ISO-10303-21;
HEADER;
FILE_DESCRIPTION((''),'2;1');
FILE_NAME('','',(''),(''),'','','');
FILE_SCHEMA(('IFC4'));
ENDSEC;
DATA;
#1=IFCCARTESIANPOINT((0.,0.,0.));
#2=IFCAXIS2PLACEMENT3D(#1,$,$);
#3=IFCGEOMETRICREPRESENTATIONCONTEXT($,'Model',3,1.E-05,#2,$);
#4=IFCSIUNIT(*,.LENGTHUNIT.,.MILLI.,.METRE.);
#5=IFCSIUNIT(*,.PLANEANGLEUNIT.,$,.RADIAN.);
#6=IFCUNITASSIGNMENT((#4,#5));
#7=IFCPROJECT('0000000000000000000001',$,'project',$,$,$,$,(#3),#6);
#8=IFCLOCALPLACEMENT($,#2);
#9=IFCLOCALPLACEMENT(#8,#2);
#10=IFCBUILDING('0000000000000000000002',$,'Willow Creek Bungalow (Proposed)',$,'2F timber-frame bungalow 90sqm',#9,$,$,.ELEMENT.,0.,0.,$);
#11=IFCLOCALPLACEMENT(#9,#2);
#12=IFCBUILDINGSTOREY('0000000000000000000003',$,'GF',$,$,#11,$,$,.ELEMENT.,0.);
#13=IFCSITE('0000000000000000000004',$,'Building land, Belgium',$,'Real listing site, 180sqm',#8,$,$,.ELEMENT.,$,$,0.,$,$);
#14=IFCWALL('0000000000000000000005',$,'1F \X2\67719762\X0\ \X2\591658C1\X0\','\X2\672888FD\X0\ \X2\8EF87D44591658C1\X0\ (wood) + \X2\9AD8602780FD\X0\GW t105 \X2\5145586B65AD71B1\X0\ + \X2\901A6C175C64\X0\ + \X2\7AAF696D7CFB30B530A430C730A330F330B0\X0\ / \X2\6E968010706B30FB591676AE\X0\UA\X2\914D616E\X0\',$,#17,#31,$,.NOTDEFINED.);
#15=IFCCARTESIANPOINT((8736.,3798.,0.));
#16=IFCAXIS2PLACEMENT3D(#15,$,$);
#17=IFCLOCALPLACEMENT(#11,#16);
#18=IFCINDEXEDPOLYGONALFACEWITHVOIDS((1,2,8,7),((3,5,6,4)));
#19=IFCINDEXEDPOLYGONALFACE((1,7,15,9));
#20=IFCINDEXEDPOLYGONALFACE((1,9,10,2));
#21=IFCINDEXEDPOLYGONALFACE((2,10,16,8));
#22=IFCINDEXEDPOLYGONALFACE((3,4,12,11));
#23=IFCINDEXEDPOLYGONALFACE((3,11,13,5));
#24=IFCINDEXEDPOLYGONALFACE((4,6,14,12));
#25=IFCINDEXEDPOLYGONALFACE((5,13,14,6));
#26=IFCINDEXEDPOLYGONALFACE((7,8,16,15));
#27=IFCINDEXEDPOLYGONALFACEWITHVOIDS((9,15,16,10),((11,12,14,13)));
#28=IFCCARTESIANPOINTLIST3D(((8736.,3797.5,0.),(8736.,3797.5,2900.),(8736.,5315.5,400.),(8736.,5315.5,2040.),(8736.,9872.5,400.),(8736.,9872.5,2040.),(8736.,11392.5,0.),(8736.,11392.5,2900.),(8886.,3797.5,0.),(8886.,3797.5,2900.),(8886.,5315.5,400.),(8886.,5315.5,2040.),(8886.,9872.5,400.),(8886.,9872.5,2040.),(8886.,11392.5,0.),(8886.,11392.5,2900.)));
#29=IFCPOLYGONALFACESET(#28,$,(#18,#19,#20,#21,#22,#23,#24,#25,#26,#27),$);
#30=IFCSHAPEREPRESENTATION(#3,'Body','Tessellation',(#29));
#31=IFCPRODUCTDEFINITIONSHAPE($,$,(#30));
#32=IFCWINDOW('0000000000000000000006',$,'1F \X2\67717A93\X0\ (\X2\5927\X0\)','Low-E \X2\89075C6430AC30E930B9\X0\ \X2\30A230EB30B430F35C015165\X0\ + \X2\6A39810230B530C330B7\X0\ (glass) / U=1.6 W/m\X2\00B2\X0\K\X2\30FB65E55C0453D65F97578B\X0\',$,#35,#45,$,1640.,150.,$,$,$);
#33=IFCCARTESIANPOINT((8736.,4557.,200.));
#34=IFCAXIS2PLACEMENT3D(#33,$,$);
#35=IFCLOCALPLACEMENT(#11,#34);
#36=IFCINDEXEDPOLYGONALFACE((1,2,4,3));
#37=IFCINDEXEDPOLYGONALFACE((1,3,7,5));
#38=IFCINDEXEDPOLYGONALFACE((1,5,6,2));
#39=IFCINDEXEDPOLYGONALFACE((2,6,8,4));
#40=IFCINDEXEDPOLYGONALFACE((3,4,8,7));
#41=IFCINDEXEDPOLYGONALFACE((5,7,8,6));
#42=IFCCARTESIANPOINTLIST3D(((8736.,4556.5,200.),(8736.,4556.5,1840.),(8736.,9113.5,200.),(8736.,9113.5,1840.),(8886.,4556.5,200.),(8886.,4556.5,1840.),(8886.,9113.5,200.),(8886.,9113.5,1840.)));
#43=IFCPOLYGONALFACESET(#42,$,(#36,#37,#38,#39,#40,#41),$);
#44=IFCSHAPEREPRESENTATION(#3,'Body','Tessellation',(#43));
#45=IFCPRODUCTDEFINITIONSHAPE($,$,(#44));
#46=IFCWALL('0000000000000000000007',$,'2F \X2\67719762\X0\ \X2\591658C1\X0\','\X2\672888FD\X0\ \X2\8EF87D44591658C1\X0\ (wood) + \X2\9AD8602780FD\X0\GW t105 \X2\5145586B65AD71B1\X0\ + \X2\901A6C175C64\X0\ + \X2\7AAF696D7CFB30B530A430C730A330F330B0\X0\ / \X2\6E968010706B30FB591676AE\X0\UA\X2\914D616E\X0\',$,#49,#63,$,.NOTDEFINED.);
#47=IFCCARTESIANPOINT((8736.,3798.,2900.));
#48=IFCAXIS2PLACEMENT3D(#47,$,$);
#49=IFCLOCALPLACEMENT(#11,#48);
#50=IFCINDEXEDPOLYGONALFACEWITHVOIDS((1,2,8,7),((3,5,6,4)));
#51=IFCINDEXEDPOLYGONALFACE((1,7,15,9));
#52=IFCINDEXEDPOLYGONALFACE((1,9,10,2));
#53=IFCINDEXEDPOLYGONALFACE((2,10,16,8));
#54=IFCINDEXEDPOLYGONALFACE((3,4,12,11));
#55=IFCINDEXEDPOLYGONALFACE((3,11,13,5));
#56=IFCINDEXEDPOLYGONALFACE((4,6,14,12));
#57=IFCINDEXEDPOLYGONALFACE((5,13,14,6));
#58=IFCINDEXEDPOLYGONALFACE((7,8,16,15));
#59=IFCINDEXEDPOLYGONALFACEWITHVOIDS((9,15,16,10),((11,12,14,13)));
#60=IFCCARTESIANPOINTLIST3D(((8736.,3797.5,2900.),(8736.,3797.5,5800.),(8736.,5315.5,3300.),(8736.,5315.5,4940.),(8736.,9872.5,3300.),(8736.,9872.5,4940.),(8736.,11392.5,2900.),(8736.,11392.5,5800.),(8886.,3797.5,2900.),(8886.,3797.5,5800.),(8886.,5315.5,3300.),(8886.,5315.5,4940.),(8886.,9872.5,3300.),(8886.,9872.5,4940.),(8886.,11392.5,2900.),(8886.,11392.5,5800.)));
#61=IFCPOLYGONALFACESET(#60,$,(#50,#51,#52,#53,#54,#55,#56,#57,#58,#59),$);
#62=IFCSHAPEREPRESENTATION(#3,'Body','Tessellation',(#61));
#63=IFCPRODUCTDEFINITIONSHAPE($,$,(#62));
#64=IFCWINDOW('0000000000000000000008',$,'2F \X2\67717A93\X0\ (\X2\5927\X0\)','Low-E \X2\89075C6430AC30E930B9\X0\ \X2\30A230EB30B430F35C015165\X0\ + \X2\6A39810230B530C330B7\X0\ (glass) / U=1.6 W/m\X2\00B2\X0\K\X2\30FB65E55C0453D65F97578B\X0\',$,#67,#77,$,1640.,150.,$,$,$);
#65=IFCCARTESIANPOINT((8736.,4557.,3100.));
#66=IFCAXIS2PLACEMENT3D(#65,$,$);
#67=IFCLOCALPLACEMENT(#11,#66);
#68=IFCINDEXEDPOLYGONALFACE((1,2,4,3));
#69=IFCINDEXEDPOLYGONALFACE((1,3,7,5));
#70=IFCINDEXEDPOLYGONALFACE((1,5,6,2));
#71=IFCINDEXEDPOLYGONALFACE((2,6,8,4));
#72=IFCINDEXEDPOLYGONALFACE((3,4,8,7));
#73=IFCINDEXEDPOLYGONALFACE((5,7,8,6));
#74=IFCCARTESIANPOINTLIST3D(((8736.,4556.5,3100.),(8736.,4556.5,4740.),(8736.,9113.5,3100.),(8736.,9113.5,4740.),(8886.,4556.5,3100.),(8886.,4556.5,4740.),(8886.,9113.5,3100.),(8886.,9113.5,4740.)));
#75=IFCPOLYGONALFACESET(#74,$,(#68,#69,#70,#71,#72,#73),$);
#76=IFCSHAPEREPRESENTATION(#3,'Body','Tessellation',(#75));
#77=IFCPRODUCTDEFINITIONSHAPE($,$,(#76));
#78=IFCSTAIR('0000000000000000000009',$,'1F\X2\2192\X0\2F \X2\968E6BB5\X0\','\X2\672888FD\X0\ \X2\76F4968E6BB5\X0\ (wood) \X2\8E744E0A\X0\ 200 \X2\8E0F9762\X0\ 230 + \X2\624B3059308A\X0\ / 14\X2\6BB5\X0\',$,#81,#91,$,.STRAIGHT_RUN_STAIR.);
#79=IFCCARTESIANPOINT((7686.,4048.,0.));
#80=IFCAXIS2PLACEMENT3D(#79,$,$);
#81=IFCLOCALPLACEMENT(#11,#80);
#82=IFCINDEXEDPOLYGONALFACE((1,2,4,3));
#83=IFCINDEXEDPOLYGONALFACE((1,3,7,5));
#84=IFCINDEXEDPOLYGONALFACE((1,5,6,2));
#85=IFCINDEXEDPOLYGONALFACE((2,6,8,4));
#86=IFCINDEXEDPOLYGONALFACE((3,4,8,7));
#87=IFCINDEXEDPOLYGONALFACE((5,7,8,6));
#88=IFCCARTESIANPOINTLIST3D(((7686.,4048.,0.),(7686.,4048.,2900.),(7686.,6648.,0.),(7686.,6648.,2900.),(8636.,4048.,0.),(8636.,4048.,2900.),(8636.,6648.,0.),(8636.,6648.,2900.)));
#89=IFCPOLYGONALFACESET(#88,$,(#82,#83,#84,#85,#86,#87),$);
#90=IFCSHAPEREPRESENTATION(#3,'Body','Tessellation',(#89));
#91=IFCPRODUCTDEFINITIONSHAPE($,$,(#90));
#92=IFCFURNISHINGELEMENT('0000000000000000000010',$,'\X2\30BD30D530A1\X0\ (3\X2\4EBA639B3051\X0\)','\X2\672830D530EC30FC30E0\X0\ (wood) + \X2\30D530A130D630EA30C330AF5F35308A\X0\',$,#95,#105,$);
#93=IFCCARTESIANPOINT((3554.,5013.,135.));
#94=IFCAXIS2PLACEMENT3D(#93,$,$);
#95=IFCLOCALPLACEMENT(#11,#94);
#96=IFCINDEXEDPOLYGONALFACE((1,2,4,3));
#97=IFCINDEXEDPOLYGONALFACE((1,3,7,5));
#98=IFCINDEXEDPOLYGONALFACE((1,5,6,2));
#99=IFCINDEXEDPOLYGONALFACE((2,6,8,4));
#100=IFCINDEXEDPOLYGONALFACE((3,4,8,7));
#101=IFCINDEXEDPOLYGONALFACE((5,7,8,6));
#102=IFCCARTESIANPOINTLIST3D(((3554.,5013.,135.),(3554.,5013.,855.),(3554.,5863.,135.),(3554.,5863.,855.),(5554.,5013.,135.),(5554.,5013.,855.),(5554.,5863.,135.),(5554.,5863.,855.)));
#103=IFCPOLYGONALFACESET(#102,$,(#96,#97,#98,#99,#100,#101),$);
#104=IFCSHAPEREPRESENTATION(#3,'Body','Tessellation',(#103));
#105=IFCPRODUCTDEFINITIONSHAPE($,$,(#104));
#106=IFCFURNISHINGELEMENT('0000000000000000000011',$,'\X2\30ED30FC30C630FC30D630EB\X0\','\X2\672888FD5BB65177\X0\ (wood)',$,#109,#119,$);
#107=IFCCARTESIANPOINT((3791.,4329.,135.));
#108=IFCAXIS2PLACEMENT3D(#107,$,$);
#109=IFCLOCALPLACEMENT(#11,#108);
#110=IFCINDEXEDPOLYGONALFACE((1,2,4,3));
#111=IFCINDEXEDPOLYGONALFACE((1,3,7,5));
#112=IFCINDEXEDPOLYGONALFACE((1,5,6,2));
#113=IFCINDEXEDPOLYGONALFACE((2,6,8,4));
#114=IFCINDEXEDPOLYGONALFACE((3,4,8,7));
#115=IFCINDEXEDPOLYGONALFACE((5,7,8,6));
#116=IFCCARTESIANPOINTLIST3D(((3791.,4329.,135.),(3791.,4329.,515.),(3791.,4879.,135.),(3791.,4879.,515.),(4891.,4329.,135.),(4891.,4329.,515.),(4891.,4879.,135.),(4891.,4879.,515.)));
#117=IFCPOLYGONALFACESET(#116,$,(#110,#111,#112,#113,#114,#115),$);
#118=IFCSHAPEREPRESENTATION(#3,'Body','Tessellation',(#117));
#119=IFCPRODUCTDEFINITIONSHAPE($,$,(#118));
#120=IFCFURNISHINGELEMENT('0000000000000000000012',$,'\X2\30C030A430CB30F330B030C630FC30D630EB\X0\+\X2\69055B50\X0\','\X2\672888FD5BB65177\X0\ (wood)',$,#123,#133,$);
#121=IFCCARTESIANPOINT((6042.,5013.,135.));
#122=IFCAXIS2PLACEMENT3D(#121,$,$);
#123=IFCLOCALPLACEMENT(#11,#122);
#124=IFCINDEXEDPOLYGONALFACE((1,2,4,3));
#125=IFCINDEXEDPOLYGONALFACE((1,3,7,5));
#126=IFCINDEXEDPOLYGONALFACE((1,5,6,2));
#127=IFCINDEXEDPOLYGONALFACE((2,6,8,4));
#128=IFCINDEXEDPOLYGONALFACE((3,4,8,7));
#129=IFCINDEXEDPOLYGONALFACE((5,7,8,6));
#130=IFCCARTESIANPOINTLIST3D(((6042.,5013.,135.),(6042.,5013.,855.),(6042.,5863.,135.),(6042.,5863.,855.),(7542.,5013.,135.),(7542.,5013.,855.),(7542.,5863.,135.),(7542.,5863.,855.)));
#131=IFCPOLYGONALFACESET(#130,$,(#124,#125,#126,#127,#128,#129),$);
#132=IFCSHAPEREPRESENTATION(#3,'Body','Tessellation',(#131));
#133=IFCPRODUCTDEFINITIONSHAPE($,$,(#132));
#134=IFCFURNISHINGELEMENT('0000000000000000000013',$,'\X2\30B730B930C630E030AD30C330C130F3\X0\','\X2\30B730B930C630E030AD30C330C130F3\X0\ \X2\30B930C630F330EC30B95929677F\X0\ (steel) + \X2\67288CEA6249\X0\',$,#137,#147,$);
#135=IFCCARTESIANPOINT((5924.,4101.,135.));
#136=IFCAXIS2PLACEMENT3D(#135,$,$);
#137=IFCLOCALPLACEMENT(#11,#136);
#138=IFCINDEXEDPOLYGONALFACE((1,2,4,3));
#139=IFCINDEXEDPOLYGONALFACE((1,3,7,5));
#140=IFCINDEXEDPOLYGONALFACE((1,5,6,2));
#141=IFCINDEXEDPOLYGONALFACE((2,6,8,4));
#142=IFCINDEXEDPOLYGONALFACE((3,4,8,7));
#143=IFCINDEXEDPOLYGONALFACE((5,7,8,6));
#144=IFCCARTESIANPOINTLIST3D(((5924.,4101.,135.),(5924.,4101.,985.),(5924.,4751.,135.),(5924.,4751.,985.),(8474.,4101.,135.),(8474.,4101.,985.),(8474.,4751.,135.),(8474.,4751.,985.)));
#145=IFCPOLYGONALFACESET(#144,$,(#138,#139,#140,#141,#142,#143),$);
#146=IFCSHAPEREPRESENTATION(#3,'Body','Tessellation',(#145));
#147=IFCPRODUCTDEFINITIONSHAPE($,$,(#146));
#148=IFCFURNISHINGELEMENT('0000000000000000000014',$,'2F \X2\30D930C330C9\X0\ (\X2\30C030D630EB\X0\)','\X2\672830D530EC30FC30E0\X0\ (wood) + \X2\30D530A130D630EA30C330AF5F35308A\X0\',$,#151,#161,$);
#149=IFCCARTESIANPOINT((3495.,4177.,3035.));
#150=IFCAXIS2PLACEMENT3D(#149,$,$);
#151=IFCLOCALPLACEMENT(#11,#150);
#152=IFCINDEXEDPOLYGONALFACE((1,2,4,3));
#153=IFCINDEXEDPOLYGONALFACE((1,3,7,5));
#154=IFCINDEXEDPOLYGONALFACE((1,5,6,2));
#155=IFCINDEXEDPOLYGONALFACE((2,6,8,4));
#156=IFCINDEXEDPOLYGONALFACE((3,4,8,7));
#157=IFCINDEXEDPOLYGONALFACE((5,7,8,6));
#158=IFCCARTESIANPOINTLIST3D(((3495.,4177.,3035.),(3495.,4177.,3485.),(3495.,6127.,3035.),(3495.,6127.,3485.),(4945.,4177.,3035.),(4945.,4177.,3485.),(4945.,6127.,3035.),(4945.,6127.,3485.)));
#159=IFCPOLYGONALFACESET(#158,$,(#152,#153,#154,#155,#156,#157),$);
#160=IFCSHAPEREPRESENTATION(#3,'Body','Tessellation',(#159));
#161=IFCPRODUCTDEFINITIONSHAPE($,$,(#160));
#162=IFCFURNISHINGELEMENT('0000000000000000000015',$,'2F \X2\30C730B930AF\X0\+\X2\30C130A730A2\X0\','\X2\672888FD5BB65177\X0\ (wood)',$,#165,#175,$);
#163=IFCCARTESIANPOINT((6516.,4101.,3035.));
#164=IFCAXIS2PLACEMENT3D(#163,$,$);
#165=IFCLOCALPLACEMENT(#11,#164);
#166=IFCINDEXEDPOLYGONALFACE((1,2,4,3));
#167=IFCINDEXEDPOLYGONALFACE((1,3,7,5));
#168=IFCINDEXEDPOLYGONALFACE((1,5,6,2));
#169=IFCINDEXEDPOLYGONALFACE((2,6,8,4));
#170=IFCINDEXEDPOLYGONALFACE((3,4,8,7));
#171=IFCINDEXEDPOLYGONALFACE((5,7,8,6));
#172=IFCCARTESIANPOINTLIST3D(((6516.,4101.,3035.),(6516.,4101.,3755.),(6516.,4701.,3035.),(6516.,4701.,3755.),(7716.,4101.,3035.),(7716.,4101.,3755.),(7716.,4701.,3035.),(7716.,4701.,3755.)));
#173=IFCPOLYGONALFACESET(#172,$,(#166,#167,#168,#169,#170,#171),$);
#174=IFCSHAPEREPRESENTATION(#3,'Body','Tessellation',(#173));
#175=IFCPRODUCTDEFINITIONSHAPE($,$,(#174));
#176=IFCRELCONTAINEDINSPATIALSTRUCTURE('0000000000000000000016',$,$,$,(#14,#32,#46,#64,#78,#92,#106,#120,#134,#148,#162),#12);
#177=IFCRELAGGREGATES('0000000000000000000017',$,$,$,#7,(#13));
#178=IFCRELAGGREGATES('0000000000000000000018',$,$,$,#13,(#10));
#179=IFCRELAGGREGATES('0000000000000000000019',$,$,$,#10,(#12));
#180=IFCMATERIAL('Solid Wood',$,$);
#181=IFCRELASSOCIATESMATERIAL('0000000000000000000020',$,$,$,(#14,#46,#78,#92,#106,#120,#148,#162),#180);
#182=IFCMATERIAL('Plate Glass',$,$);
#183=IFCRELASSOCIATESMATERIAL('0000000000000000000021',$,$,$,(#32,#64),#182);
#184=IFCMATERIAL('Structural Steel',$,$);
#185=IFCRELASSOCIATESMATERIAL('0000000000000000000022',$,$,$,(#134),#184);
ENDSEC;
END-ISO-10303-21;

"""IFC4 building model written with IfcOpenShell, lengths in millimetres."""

from ifc_helpers import new_model, si_unit, frame, frame_2d, origin, place, context, project, spatial, rectangle, extrude, material, element, fill, save


model = new_model("IFC4")

# Units and contexts
model_context = context("Model", 3, precision=1e-05, world=origin())
ifc_project = project(units=[si_unit("LENGTHUNIT", "METRE", prefix="MILLI"), si_unit("PLANEANGLEUNIT", "RADIAN")], contexts=[model_context])

# Site, building, storey
site_placement = place(None, origin())
site = spatial("IfcSite", under=ifc_project, at=site_placement, Name="Building land, Belgium", ObjectType="Real listing site, 180sqm", CompositionType="ELEMENT", RefElevation=0.0)
building_placement = place(site_placement, origin())
building = spatial("IfcBuilding", under=site, at=building_placement, Name="Willow Creek Bungalow (Proposed)", ObjectType="2F timber-frame bungalow 90sqm", CompositionType="ELEMENT", ElevationOfRefHeight=0.0, ElevationOfTerrain=0.0)
storey_placement = place(building_placement, origin())
storey = spatial("IfcBuildingStorey", under=building, at=storey_placement, Name="GF", CompositionType="ELEMENT", Elevation=0.0)

# Wall, opening, window
ifc_material_1 = material(Name="Solid Wood")
wall_1_placement = place(storey_placement, frame((8736.0, 3798.0, 0.0)))
wall_1 = element("IfcWall", 1, at=wall_1_placement, inside=storey, material=ifc_material_1, Name="1F 東面 外壁", Description="木製 軸組外壁 (wood) + 高性能GW t105 充填断熱 + 通気層 + 窯業系サイディング / 準耐火・外皮UA配慮", PredefinedType="NOTDEFINED", context=model_context, shape_type="SweptSolid", body=[
    extrude(rectangle(XDim=150.0, YDim=7595.0, at=frame_2d((75.0, 3797.0))), frame((8736.0, 3798.0, 0.0)), (0.0, 0.0, 1.0), 2900.0),
])
opening_1_placement = place(storey_placement, frame((8736.0, 4557.0, 200.0)))
opening_1 = element("IfcOpeningElement", 2, at=opening_1_placement, cuts=wall_1, PredefinedType="NOTDEFINED", context=model_context, shape_type="SweptSolid", body=[
    extrude(rectangle(XDim=150.0, YDim=4557.0, at=frame_2d((75.0, 2278.0))), frame((8736.0, 4557.0, 200.0)), (0.0, 0.0, 1.0), 1640.0),
])
ifc_material_2 = material(Name="Plate Glass")
window_1_placement = place(storey_placement, frame((8736.0, 4557.0, 200.0)))
window_1 = element("IfcWindow", 3, at=window_1_placement, inside=storey, material=ifc_material_2, Name="1F 東窓 (大)", Description="Low-E 複層ガラス アルゴン封入 + 樹脂サッシ (glass) / U=1.6 W/m²K・日射取得型", OverallHeight=1640.0, OverallWidth=150.0, context=model_context, shape_type="SweptSolid", body=[
    extrude(rectangle(XDim=150.0, YDim=4557.0, at=frame_2d((75.0, 2278.0))), frame((8736.0, 4557.0, 200.0)), (0.0, 0.0, 1.0), 1640.0),
])
fill(opening_1, window_1)

# Wall, opening, window
wall_2_placement = place(storey_placement, frame((8736.0, 3798.0, 2900.0)))
wall_2 = element("IfcWall", 4, at=wall_2_placement, inside=storey, material=ifc_material_1, Name="2F 東面 外壁", Description="木製 軸組外壁 (wood) + 高性能GW t105 充填断熱 + 通気層 + 窯業系サイディング / 準耐火・外皮UA配慮", PredefinedType="NOTDEFINED", context=model_context, shape_type="SweptSolid", body=[
    extrude(rectangle(XDim=150.0, YDim=7595.0, at=frame_2d((75.0, 3797.0))), frame((8736.0, 3798.0, 2900.0)), (0.0, 0.0, 1.0), 2900.0),
])
opening_2_placement = place(storey_placement, frame((8736.0, 4557.0, 3100.0)))
opening_2 = element("IfcOpeningElement", 5, at=opening_2_placement, cuts=wall_2, PredefinedType="NOTDEFINED", context=model_context, shape_type="SweptSolid", body=[
    extrude(rectangle(XDim=150.0, YDim=4557.0, at=frame_2d((75.0, 2278.0))), frame((8736.0, 4557.0, 3100.0)), (0.0, 0.0, 1.0), 1640.0),
])
window_2_placement = place(storey_placement, frame((8736.0, 4557.0, 3100.0)))
window_2 = element("IfcWindow", 6, at=window_2_placement, inside=storey, material=ifc_material_2, Name="2F 東窓 (大)", Description="Low-E 複層ガラス アルゴン封入 + 樹脂サッシ (glass) / U=1.6 W/m²K・日射取得型", OverallHeight=1640.0, OverallWidth=150.0, context=model_context, shape_type="SweptSolid", body=[
    extrude(rectangle(XDim=150.0, YDim=4557.0, at=frame_2d((75.0, 2278.0))), frame((8736.0, 4557.0, 3100.0)), (0.0, 0.0, 1.0), 1640.0),
])
fill(opening_2, window_2)

# Stair
stair_placement = place(storey_placement, frame((7686.0, 4048.0, 0.0)))
element("IfcStair", 7, at=stair_placement, inside=storey, material=ifc_material_1, Name="1F→2F 階段", Description="木製 直階段 (wood) 蹴上 200 踏面 230 + 手すり / 14段", PredefinedType="STRAIGHT_RUN_STAIR", context=model_context, shape_type="SweptSolid", body=[
    extrude(rectangle(XDim=950.0, YDim=2600.0, at=frame_2d((475.0, 1300.0))), frame((7686.0, 4048.0, 0.0)), (0.0, 0.0, 1.0), 2900.0),
])

# Furnishing elements
furnishing_1_placement = place(storey_placement, frame((3554.0, 5013.0, 135.0)))
element("IfcFurnishingElement", 8, at=furnishing_1_placement, inside=storey, material=ifc_material_1, Name="ソファ (3人掛け)", Description="木フレーム (wood) + ファブリック張り", context=model_context, shape_type="SweptSolid", body=[
    extrude(rectangle(XDim=2000.0, YDim=850.0, at=frame_2d((1000.0, 425.0))), frame((3554.0, 5013.0, 135.0)), (0.0, 0.0, 1.0), 720.0),
])
furnishing_2_placement = place(storey_placement, frame((3791.0, 4329.0, 135.0)))
element("IfcFurnishingElement", 9, at=furnishing_2_placement, inside=storey, material=ifc_material_1, Name="ローテーブル", Description="木製家具 (wood)", context=model_context, shape_type="SweptSolid", body=[
    extrude(rectangle(XDim=1100.0, YDim=550.0, at=frame_2d((550.0, 275.0))), frame((3791.0, 4329.0, 135.0)), (0.0, 0.0, 1.0), 380.0),
])
furnishing_3_placement = place(storey_placement, frame((6042.0, 5013.0, 135.0)))
element("IfcFurnishingElement", 10, at=furnishing_3_placement, inside=storey, material=ifc_material_1, Name="ダイニングテーブル+椅子", Description="木製家具 (wood)", context=model_context, shape_type="SweptSolid", body=[
    extrude(rectangle(XDim=1500.0, YDim=850.0, at=frame_2d((750.0, 425.0))), frame((6042.0, 5013.0, 135.0)), (0.0, 0.0, 1.0), 720.0),
])
ifc_material_3 = material(Name="Structural Steel")
furnishing_4_placement = place(storey_placement, frame((5924.0, 4101.0, 135.0)))
element("IfcFurnishingElement", 11, at=furnishing_4_placement, inside=storey, material=ifc_material_3, Name="システムキッチン", Description="システムキッチン ステンレス天板 (steel) + 木質扉", context=model_context, shape_type="SweptSolid", body=[
    extrude(rectangle(XDim=2550.0, YDim=650.0, at=frame_2d((1275.0, 325.0))), frame((5924.0, 4101.0, 135.0)), (0.0, 0.0, 1.0), 850.0),
])
furnishing_5_placement = place(storey_placement, frame((3495.0, 4177.0, 3035.0)))
element("IfcFurnishingElement", 12, at=furnishing_5_placement, inside=storey, material=ifc_material_1, Name="2F ベッド (ダブル)", Description="木フレーム (wood) + ファブリック張り", context=model_context, shape_type="SweptSolid", body=[
    extrude(rectangle(XDim=1450.0, YDim=1950.0, at=frame_2d((725.0, 975.0))), frame((3495.0, 4177.0, 3035.0)), (0.0, 0.0, 1.0), 450.0),
])
furnishing_6_placement = place(storey_placement, frame((6516.0, 4101.0, 3035.0)))
element("IfcFurnishingElement", 13, at=furnishing_6_placement, inside=storey, material=ifc_material_1, Name="2F デスク+チェア", Description="木製家具 (wood)", context=model_context, shape_type="SweptSolid", body=[
    extrude(rectangle(XDim=1200.0, YDim=600.0, at=frame_2d((600.0, 300.0))), frame((6516.0, 4101.0, 3035.0)), (0.0, 0.0, 1.0), 720.0),
])

save(model, "model.ifc")
